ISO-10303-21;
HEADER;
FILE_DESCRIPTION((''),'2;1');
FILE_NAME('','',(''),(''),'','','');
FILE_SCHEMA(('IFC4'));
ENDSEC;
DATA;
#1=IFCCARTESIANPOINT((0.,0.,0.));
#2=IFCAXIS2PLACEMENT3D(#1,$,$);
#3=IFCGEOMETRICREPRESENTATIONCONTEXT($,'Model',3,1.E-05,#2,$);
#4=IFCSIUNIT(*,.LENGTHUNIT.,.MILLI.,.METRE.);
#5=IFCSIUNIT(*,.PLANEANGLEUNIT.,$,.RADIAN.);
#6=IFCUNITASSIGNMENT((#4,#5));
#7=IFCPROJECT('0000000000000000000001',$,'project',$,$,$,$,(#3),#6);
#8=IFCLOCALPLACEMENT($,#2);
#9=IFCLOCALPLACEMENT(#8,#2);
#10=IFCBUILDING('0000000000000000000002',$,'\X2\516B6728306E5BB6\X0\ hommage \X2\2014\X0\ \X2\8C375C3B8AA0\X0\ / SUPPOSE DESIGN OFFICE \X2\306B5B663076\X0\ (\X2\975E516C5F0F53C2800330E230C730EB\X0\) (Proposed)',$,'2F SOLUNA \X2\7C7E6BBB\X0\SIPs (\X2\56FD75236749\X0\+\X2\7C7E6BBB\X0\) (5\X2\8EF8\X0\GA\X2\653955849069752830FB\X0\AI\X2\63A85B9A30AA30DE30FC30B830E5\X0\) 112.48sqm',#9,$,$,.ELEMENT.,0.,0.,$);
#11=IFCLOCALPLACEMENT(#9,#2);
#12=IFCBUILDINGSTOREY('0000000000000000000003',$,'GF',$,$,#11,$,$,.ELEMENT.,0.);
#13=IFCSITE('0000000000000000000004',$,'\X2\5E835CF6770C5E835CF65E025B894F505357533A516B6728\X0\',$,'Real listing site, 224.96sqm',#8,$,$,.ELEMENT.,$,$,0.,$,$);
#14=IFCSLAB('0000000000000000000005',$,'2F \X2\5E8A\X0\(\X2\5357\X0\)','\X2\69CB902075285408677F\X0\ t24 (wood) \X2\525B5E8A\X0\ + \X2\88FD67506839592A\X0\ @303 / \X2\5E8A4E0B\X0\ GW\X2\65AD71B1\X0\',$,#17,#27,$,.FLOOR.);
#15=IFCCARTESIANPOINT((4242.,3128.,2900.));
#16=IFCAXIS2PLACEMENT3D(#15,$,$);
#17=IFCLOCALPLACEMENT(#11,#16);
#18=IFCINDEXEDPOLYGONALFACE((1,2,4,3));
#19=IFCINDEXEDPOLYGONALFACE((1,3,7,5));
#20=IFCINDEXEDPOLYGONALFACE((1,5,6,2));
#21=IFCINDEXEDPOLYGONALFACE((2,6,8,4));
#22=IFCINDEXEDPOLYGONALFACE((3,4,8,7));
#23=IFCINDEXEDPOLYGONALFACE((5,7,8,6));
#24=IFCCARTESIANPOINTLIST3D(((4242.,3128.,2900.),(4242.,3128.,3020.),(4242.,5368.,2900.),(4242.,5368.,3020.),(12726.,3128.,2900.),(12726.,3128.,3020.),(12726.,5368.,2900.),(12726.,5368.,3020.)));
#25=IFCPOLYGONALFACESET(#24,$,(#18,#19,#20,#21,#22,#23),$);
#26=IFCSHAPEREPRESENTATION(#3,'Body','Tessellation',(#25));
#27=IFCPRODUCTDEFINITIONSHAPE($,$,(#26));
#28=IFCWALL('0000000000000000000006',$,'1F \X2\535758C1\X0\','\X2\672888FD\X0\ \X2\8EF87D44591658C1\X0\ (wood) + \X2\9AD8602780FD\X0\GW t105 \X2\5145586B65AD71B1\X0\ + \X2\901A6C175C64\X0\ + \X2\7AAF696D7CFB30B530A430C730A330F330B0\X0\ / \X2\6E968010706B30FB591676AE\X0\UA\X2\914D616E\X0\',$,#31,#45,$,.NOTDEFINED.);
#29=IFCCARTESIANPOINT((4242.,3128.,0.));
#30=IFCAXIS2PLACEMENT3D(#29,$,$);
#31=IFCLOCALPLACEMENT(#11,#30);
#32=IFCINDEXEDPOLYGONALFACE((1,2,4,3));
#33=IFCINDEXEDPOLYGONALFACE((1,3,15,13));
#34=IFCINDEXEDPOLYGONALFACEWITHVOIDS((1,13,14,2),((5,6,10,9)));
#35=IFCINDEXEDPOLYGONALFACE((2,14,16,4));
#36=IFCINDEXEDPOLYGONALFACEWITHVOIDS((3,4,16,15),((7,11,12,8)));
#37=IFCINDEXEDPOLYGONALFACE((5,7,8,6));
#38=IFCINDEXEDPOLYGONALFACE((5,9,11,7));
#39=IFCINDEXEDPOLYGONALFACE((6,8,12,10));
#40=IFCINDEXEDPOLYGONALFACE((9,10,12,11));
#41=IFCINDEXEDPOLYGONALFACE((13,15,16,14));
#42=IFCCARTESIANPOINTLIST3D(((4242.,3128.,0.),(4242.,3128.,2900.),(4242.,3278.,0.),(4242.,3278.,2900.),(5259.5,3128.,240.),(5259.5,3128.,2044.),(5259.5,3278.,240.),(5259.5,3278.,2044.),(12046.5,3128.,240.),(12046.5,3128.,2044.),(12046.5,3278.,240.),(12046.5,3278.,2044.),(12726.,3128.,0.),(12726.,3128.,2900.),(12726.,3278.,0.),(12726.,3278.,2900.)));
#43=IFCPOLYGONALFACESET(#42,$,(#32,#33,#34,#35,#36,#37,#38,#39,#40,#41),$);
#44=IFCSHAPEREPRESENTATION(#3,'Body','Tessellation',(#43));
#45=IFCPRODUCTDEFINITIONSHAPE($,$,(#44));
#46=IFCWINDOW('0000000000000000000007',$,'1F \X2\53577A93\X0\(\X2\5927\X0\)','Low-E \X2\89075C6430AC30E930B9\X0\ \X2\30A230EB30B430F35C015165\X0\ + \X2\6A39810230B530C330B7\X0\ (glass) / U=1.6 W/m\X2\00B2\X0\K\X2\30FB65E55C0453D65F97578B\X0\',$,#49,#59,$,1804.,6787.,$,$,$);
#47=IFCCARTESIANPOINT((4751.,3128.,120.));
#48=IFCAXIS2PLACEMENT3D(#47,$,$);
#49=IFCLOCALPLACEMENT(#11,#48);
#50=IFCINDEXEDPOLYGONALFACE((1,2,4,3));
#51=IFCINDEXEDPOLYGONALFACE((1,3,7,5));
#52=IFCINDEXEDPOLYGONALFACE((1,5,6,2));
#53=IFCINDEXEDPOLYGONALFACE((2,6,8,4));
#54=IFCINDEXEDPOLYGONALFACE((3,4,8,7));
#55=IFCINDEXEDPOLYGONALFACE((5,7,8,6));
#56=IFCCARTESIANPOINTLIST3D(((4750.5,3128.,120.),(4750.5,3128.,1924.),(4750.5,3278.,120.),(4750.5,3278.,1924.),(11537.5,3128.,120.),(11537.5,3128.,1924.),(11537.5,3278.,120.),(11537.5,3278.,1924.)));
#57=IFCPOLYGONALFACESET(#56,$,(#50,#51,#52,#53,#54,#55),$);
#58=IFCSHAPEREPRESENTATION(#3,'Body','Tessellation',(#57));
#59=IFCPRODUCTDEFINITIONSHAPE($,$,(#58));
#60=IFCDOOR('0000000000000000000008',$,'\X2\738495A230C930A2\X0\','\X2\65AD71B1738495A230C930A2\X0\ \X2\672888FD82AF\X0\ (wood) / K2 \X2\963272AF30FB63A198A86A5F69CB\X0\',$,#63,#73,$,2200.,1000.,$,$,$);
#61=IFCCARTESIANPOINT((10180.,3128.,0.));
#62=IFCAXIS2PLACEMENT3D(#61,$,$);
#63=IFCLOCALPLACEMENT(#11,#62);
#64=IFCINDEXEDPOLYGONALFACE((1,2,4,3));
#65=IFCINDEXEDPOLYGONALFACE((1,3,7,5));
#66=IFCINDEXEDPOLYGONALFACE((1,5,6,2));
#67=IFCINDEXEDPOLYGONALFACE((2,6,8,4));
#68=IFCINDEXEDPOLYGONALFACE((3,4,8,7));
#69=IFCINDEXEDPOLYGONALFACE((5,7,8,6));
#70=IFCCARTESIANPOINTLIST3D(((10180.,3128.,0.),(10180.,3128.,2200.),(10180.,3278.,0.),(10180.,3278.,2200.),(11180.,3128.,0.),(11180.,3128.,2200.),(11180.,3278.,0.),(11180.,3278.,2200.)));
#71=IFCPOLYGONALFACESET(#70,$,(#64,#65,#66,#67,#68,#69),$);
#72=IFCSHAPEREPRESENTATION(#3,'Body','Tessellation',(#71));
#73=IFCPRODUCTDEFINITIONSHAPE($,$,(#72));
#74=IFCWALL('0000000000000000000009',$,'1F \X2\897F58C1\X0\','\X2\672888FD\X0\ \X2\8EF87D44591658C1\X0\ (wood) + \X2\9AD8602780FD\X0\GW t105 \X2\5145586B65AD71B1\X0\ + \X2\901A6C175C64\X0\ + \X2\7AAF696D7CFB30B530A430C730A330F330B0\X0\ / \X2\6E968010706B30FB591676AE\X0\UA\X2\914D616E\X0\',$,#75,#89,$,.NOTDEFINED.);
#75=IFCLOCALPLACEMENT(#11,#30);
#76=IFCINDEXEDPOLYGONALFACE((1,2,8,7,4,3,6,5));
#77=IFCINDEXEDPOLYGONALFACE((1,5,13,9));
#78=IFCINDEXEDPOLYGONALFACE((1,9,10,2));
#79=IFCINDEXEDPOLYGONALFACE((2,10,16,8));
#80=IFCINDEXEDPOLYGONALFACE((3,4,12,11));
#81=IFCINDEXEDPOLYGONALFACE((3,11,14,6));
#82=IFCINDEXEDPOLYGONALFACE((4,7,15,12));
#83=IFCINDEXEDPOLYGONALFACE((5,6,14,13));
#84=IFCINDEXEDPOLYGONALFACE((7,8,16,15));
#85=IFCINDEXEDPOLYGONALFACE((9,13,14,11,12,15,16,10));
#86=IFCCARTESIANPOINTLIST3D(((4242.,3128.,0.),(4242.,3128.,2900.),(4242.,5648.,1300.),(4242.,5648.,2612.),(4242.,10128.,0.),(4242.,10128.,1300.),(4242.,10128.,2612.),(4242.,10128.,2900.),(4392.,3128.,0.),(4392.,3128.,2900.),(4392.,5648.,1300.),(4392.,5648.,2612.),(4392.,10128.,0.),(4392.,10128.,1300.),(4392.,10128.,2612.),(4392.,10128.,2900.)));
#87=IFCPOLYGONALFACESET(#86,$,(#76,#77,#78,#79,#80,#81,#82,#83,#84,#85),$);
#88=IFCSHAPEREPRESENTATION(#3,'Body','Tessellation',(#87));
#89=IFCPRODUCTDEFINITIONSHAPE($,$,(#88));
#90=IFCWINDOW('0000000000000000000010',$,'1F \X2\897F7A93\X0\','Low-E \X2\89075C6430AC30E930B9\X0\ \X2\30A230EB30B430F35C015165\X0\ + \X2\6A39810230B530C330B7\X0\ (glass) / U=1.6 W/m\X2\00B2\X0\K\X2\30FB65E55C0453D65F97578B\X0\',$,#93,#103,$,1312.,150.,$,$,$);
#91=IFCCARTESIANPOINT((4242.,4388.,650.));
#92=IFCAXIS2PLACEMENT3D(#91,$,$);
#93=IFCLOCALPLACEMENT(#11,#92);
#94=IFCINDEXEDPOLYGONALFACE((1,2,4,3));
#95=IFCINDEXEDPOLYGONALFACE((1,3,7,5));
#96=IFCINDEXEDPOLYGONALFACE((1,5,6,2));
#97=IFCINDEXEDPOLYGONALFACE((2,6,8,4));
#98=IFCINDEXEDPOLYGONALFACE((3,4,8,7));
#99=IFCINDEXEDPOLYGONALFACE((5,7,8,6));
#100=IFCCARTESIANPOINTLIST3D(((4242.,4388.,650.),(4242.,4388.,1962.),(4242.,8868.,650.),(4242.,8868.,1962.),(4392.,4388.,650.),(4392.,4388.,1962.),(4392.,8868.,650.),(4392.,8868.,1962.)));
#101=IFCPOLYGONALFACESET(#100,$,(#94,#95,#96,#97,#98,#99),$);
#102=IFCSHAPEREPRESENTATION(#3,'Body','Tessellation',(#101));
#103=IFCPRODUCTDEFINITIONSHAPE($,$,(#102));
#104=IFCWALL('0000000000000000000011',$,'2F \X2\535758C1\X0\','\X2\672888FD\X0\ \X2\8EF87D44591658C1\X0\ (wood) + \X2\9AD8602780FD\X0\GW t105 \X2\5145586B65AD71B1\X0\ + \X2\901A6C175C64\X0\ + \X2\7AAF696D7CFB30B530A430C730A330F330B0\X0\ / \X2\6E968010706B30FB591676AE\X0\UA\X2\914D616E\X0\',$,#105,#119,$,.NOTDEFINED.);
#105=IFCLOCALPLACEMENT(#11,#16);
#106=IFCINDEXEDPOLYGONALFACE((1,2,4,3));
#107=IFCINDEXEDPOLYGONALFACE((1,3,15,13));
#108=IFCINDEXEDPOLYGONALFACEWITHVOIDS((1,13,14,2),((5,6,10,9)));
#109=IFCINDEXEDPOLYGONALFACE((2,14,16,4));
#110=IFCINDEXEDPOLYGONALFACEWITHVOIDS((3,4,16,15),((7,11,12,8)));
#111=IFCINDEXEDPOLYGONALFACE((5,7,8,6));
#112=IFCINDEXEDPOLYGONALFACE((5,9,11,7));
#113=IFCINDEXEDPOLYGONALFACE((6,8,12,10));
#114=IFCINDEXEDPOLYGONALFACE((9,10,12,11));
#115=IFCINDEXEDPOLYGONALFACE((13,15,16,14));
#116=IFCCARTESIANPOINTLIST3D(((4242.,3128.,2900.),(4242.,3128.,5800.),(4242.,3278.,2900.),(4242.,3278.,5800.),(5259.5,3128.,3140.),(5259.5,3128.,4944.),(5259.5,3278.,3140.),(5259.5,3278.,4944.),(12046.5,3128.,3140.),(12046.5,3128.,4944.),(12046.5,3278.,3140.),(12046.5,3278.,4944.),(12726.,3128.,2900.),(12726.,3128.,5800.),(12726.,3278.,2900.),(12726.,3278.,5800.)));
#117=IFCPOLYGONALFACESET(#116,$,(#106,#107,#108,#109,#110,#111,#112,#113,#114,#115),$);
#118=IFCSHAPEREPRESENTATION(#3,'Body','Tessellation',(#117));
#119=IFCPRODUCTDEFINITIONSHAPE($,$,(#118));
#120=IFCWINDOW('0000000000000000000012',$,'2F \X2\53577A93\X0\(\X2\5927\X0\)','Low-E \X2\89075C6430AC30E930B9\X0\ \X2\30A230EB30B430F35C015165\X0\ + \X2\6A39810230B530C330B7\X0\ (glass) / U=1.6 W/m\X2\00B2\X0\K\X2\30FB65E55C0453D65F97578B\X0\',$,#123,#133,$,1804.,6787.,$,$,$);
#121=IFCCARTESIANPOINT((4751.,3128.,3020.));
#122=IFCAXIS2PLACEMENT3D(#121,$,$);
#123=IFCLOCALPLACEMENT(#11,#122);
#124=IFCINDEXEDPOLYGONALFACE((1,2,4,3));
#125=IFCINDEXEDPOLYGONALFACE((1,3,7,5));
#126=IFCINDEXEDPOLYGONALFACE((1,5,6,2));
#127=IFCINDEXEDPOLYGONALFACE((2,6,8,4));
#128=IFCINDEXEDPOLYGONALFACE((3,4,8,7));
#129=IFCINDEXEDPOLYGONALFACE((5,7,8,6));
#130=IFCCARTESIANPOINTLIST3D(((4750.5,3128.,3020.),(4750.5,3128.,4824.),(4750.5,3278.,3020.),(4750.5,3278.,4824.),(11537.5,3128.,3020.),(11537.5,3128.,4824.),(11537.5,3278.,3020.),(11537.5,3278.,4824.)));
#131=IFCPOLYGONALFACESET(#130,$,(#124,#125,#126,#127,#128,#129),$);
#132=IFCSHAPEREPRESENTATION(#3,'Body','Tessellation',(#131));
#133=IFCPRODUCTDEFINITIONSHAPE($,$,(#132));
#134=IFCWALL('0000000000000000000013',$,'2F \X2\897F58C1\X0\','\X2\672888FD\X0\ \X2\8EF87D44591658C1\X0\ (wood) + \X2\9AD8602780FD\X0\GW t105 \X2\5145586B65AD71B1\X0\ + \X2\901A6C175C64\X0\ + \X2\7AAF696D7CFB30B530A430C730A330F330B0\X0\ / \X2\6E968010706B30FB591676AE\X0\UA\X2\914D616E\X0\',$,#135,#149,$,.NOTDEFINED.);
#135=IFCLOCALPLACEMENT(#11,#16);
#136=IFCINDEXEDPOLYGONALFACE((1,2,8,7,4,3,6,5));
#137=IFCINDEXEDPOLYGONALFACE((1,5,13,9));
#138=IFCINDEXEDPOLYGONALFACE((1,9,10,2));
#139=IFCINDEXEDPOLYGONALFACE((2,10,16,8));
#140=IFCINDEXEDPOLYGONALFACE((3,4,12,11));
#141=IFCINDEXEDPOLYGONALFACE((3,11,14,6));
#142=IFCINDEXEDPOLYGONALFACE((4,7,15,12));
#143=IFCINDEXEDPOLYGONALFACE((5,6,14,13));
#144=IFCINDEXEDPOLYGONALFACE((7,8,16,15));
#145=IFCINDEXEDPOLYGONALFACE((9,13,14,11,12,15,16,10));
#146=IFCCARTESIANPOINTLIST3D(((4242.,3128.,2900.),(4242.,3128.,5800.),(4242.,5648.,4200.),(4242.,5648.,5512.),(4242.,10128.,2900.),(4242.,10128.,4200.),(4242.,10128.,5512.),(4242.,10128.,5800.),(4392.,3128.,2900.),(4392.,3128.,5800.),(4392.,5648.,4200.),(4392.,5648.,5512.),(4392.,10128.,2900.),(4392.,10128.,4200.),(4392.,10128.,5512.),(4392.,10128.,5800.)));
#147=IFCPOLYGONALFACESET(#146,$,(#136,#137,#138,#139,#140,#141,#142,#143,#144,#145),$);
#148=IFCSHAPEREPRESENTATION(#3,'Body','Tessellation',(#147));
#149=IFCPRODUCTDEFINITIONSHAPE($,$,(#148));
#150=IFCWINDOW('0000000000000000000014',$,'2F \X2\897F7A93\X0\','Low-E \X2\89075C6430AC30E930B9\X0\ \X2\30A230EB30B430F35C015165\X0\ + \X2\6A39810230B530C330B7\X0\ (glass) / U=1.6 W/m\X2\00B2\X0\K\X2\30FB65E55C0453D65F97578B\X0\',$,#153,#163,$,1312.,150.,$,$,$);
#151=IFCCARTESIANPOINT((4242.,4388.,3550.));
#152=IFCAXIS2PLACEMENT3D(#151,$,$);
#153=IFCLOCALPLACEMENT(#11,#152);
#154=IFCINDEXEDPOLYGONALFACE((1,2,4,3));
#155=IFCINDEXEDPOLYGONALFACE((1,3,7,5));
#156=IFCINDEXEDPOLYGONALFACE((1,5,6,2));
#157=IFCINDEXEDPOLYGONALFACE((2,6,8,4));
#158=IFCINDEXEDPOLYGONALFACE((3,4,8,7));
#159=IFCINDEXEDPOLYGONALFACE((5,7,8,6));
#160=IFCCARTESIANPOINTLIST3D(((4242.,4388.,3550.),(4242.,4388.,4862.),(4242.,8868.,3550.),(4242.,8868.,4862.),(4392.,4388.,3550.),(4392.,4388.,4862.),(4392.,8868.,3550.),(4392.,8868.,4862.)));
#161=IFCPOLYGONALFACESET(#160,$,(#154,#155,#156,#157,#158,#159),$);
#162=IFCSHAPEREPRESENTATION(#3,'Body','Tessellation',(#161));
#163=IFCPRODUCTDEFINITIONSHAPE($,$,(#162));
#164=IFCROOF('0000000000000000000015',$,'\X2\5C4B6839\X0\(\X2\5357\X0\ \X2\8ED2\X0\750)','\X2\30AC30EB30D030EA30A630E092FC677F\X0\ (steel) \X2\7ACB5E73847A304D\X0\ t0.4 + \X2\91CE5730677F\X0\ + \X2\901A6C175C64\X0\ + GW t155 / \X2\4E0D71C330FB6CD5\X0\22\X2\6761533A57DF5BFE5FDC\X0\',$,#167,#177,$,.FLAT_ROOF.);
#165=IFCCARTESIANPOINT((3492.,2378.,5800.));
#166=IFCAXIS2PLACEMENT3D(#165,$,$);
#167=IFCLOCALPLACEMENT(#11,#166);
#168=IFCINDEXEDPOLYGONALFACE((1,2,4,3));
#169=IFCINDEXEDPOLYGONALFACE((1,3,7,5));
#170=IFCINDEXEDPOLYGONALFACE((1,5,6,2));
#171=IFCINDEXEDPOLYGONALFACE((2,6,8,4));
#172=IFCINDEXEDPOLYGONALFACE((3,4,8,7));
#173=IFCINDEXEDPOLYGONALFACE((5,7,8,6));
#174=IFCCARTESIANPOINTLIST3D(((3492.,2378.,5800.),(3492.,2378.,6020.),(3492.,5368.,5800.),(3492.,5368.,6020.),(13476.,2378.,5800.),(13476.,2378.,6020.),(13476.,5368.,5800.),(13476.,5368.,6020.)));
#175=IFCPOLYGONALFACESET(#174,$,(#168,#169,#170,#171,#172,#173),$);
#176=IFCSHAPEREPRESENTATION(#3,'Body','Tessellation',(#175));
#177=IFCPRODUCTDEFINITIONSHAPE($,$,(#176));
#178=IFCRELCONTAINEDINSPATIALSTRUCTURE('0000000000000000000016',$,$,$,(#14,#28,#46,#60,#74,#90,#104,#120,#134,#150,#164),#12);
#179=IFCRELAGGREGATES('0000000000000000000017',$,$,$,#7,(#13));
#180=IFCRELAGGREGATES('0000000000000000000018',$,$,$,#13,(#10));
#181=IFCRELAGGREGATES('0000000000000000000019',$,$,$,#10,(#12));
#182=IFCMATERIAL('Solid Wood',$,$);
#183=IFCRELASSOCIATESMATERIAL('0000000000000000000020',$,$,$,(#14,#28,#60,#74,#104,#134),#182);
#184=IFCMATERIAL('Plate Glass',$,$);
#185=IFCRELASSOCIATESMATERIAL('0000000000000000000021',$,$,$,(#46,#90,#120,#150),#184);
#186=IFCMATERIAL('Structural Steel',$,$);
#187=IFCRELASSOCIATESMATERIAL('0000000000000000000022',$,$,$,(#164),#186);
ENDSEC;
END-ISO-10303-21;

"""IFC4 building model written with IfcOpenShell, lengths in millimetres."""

from ifc_helpers import new_model, si_unit, frame, frame_2d, origin, place, context, project, spatial, rectangle, extrude, material, element, fill, save


model = new_model("IFC4")

# Units and contexts
model_context = context("Model", 3, precision=1e-05, world=origin())
ifc_project = project(units=[si_unit("LENGTHUNIT", "METRE", prefix="MILLI"), si_unit("PLANEANGLEUNIT", "RADIAN")], contexts=[model_context])

# Site, building, storey
site_placement = place(None, origin())
site = spatial("IfcSite", under=ifc_project, at=site_placement, Name="広島県広島市安佐南区八木", ObjectType="Real listing site, 224.96sqm", CompositionType="ELEMENT", RefElevation=0.0)
building_placement = place(site_placement, origin())
building = spatial("IfcBuilding", under=site, at=building_placement, Name="八木の家 hommage — 谷尻誠 / SUPPOSE DESIGN OFFICE に学ぶ (非公式参考モデル) (Proposed)", ObjectType="2F SOLUNA 籾殻SIPs (国産杉+籾殻) (5軸GA改善適用・AI推定オマージュ) 112.48sqm", CompositionType="ELEMENT", ElevationOfRefHeight=0.0, ElevationOfTerrain=0.0)
storey_placement = place(building_placement, origin())
storey = spatial("IfcBuildingStorey", under=building, at=storey_placement, Name="GF", CompositionType="ELEMENT", Elevation=0.0)

# Slab
ifc_material_1 = material(Name="Solid Wood")
slab_1_placement = place(storey_placement, frame((4242.0, 3128.0, 2900.0)))
element("IfcSlab", 1, at=slab_1_placement, inside=storey, material=ifc_material_1, Name="2F 床(南)", Description="構造用合板 t24 (wood) 剛床 + 製材根太 @303 / 床下 GW断熱", PredefinedType="FLOOR", context=model_context, shape_type="SweptSolid", body=[
    extrude(rectangle(XDim=8484.0, YDim=2240.0, at=frame_2d((4242.0, 1120.0))), frame((4242.0, 3128.0, 2900.0)), (0.0, 0.0, 1.0), 120.0),
])

# Wall, openings, window, door
wall_1_placement = place(storey_placement, frame((4242.0, 3128.0, 0.0)))
wall_1 = element("IfcWall", 2, at=wall_1_placement, inside=storey, material=ifc_material_1, Name="1F 南壁", Description="木製 軸組外壁 (wood) + 高性能GW t105 充填断熱 + 通気層 + 窯業系サイディング / 準耐火・外皮UA配慮", PredefinedType="NOTDEFINED", context=model_context, shape_type="SweptSolid", body=[
    extrude(rectangle(XDim=8484.0, YDim=150.0, at=frame_2d((4242.0, 75.0))), frame((4242.0, 3128.0, 0.0)), (0.0, 0.0, 1.0), 2900.0),
])
opening_1_placement = place(storey_placement, frame((4751.0, 3128.0, 120.0)))
opening_1 = element("IfcOpeningElement", 3, at=opening_1_placement, cuts=wall_1, PredefinedType="NOTDEFINED", context=model_context, shape_type="SweptSolid", body=[
    extrude(rectangle(XDim=6787.0, YDim=150.0, at=frame_2d((3393.0, 75.0))), frame((4751.0, 3128.0, 120.0)), (0.0, 0.0, 1.0), 1804.0),
])
opening_2_placement = place(storey_placement, frame((10180.0, 3128.0, 0.0)))
opening_2 = element("IfcOpeningElement", 4, at=opening_2_placement, cuts=wall_1, PredefinedType="NOTDEFINED", context=model_context, shape_type="SweptSolid", body=[
    extrude(rectangle(XDim=1000.0, YDim=150.0, at=frame_2d((500.0, 75.0))), frame((10180.0, 3128.0, 0.0)), (0.0, 0.0, 1.0), 2200.0),
])
ifc_material_2 = material(Name="Plate Glass")
window_1_placement = place(storey_placement, frame((4751.0, 3128.0, 120.0)))
window_1 = element("IfcWindow", 5, at=window_1_placement, inside=storey, material=ifc_material_2, Name="1F 南窓(大)", Description="Low-E 複層ガラス アルゴン封入 + 樹脂サッシ (glass) / U=1.6 W/m²K・日射取得型", OverallHeight=1804.0, OverallWidth=6787.0, context=model_context, shape_type="SweptSolid", body=[
    extrude(rectangle(XDim=6787.0, YDim=150.0, at=frame_2d((3393.0, 75.0))), frame((4751.0, 3128.0, 120.0)), (0.0, 0.0, 1.0), 1804.0),
])
fill(opening_1, window_1)
door_placement = place(storey_placement, frame((10180.0, 3128.0, 0.0)))
door = element("IfcDoor", 6, at=door_placement, inside=storey, material=ifc_material_1, Name="玄関ドア", Description="断熱玄関ドア 木製芯 (wood) / K2 防犯・採風機構", OverallHeight=2200.0, OverallWidth=1000.0, context=model_context, shape_type="SweptSolid", body=[
    extrude(rectangle(XDim=1000.0, YDim=150.0, at=frame_2d((500.0, 75.0))), frame((10180.0, 3128.0, 0.0)), (0.0, 0.0, 1.0), 2200.0),
])
fill(opening_2, door)

# Walls, openings, windows
wall_2_placement = place(storey_placement, frame((4242.0, 3128.0, 0.0)))
wall_2 = element("IfcWall", 7, at=wall_2_placement, inside=storey, material=ifc_material_1, Name="1F 西壁", Description="木製 軸組外壁 (wood) + 高性能GW t105 充填断熱 + 通気層 + 窯業系サイディング / 準耐火・外皮UA配慮", PredefinedType="NOTDEFINED", context=model_context, shape_type="SweptSolid", body=[
    extrude(rectangle(XDim=150.0, YDim=7000.0, at=frame_2d((75.0, 3500.0))), frame((4242.0, 3128.0, 0.0)), (0.0, 0.0, 1.0), 2900.0),
])
opening_3_placement = place(storey_placement, frame((4242.0, 4388.0, 650.0)))
opening_3 = element("IfcOpeningElement", 8, at=opening_3_placement, cuts=wall_2, PredefinedType="NOTDEFINED", context=model_context, shape_type="SweptSolid", body=[
    extrude(rectangle(XDim=150.0, YDim=4480.0, at=frame_2d((75.0, 2240.0))), frame((4242.0, 4388.0, 650.0)), (0.0, 0.0, 1.0), 1312.0),
])
window_2_placement = place(storey_placement, frame((4242.0, 4388.0, 650.0)))
window_2 = element("IfcWindow", 9, at=window_2_placement, inside=storey, material=ifc_material_2, Name="1F 西窓", Description="Low-E 複層ガラス アルゴン封入 + 樹脂サッシ (glass) / U=1.6 W/m²K・日射取得型", OverallHeight=1312.0, OverallWidth=150.0, context=model_context, shape_type="SweptSolid", body=[
    extrude(rectangle(XDim=150.0, YDim=4480.0, at=frame_2d((75.0, 2240.0))), frame((4242.0, 4388.0, 650.0)), (0.0, 0.0, 1.0), 1312.0),
])
fill(opening_3, window_2)
wall_3_placement = place(storey_placement, frame((4242.0, 3128.0, 2900.0)))
wall_3 = element("IfcWall", 10, at=wall_3_placement, inside=storey, material=ifc_material_1, Name="2F 南壁", Description="木製 軸組外壁 (wood) + 高性能GW t105 充填断熱 + 通気層 + 窯業系サイディング / 準耐火・外皮UA配慮", PredefinedType="NOTDEFINED", context=model_context, shape_type="SweptSolid", body=[
    extrude(rectangle(XDim=8484.0, YDim=150.0, at=frame_2d((4242.0, 75.0))), frame((4242.0, 3128.0, 2900.0)), (0.0, 0.0, 1.0), 2900.0),
])
opening_4_placement = place(storey_placement, frame((4751.0, 3128.0, 3020.0)))
opening_4 = element("IfcOpeningElement", 11, at=opening_4_placement, cuts=wall_3, PredefinedType="NOTDEFINED", context=model_context, shape_type="SweptSolid", body=[
    extrude(rectangle(XDim=6787.0, YDim=150.0, at=frame_2d((3393.0, 75.0))), frame((4751.0, 3128.0, 3020.0)), (0.0, 0.0, 1.0), 1804.0),
])
window_3_placement = place(storey_placement, frame((4751.0, 3128.0, 3020.0)))
window_3 = element("IfcWindow", 12, at=window_3_placement, inside=storey, material=ifc_material_2, Name="2F 南窓(大)", Description="Low-E 複層ガラス アルゴン封入 + 樹脂サッシ (glass) / U=1.6 W/m²K・日射取得型", OverallHeight=1804.0, OverallWidth=6787.0, context=model_context, shape_type="SweptSolid", body=[
    extrude(rectangle(XDim=6787.0, YDim=150.0, at=frame_2d((3393.0, 75.0))), frame((4751.0, 3128.0, 3020.0)), (0.0, 0.0, 1.0), 1804.0),
])
fill(opening_4, window_3)
wall_4_placement = place(storey_placement, frame((4242.0, 3128.0, 2900.0)))
wall_4 = element("IfcWall", 13, at=wall_4_placement, inside=storey, material=ifc_material_1, Name="2F 西壁", Description="木製 軸組外壁 (wood) + 高性能GW t105 充填断熱 + 通気層 + 窯業系サイディング / 準耐火・外皮UA配慮", PredefinedType="NOTDEFINED", context=model_context, shape_type="SweptSolid", body=[
    extrude(rectangle(XDim=150.0, YDim=7000.0, at=frame_2d((75.0, 3500.0))), frame((4242.0, 3128.0, 2900.0)), (0.0, 0.0, 1.0), 2900.0),
])
opening_5_placement = place(storey_placement, frame((4242.0, 4388.0, 3550.0)))
opening_5 = element("IfcOpeningElement", 14, at=opening_5_placement, cuts=wall_4, PredefinedType="NOTDEFINED", context=model_context, shape_type="SweptSolid", body=[
    extrude(rectangle(XDim=150.0, YDim=4480.0, at=frame_2d((75.0, 2240.0))), frame((4242.0, 4388.0, 3550.0)), (0.0, 0.0, 1.0), 1312.0),
])
window_4_placement = place(storey_placement, frame((4242.0, 4388.0, 3550.0)))
window_4 = element("IfcWindow", 15, at=window_4_placement, inside=storey, material=ifc_material_2, Name="2F 西窓", Description="Low-E 複層ガラス アルゴン封入 + 樹脂サッシ (glass) / U=1.6 W/m²K・日射取得型", OverallHeight=1312.0, OverallWidth=150.0, context=model_context, shape_type="SweptSolid", body=[
    extrude(rectangle(XDim=150.0, YDim=4480.0, at=frame_2d((75.0, 2240.0))), frame((4242.0, 4388.0, 3550.0)), (0.0, 0.0, 1.0), 1312.0),
])
fill(opening_5, window_4)

# Roof
ifc_material_3 = material(Name="Structural Steel")
roof_1_placement = place(storey_placement, frame((3492.0, 2378.0, 5800.0)))
element("IfcRoof", 16, at=roof_1_placement, inside=storey, material=ifc_material_3, Name="屋根(南 軒750)", Description="ガルバリウム鋼板 (steel) 立平葺き t0.4 + 野地板 + 通気層 + GW t155 / 不燃・法22条区域対応", PredefinedType="FLAT_ROOF", context=model_context, shape_type="SweptSolid", body=[
    extrude(rectangle(XDim=9984.0, YDim=2990.0, at=frame_2d((4992.0, 1495.0))), frame((3492.0, 2378.0, 5800.0)), (0.0, 0.0, 1.0), 220.0),
])

save(model, "model.ifc")
